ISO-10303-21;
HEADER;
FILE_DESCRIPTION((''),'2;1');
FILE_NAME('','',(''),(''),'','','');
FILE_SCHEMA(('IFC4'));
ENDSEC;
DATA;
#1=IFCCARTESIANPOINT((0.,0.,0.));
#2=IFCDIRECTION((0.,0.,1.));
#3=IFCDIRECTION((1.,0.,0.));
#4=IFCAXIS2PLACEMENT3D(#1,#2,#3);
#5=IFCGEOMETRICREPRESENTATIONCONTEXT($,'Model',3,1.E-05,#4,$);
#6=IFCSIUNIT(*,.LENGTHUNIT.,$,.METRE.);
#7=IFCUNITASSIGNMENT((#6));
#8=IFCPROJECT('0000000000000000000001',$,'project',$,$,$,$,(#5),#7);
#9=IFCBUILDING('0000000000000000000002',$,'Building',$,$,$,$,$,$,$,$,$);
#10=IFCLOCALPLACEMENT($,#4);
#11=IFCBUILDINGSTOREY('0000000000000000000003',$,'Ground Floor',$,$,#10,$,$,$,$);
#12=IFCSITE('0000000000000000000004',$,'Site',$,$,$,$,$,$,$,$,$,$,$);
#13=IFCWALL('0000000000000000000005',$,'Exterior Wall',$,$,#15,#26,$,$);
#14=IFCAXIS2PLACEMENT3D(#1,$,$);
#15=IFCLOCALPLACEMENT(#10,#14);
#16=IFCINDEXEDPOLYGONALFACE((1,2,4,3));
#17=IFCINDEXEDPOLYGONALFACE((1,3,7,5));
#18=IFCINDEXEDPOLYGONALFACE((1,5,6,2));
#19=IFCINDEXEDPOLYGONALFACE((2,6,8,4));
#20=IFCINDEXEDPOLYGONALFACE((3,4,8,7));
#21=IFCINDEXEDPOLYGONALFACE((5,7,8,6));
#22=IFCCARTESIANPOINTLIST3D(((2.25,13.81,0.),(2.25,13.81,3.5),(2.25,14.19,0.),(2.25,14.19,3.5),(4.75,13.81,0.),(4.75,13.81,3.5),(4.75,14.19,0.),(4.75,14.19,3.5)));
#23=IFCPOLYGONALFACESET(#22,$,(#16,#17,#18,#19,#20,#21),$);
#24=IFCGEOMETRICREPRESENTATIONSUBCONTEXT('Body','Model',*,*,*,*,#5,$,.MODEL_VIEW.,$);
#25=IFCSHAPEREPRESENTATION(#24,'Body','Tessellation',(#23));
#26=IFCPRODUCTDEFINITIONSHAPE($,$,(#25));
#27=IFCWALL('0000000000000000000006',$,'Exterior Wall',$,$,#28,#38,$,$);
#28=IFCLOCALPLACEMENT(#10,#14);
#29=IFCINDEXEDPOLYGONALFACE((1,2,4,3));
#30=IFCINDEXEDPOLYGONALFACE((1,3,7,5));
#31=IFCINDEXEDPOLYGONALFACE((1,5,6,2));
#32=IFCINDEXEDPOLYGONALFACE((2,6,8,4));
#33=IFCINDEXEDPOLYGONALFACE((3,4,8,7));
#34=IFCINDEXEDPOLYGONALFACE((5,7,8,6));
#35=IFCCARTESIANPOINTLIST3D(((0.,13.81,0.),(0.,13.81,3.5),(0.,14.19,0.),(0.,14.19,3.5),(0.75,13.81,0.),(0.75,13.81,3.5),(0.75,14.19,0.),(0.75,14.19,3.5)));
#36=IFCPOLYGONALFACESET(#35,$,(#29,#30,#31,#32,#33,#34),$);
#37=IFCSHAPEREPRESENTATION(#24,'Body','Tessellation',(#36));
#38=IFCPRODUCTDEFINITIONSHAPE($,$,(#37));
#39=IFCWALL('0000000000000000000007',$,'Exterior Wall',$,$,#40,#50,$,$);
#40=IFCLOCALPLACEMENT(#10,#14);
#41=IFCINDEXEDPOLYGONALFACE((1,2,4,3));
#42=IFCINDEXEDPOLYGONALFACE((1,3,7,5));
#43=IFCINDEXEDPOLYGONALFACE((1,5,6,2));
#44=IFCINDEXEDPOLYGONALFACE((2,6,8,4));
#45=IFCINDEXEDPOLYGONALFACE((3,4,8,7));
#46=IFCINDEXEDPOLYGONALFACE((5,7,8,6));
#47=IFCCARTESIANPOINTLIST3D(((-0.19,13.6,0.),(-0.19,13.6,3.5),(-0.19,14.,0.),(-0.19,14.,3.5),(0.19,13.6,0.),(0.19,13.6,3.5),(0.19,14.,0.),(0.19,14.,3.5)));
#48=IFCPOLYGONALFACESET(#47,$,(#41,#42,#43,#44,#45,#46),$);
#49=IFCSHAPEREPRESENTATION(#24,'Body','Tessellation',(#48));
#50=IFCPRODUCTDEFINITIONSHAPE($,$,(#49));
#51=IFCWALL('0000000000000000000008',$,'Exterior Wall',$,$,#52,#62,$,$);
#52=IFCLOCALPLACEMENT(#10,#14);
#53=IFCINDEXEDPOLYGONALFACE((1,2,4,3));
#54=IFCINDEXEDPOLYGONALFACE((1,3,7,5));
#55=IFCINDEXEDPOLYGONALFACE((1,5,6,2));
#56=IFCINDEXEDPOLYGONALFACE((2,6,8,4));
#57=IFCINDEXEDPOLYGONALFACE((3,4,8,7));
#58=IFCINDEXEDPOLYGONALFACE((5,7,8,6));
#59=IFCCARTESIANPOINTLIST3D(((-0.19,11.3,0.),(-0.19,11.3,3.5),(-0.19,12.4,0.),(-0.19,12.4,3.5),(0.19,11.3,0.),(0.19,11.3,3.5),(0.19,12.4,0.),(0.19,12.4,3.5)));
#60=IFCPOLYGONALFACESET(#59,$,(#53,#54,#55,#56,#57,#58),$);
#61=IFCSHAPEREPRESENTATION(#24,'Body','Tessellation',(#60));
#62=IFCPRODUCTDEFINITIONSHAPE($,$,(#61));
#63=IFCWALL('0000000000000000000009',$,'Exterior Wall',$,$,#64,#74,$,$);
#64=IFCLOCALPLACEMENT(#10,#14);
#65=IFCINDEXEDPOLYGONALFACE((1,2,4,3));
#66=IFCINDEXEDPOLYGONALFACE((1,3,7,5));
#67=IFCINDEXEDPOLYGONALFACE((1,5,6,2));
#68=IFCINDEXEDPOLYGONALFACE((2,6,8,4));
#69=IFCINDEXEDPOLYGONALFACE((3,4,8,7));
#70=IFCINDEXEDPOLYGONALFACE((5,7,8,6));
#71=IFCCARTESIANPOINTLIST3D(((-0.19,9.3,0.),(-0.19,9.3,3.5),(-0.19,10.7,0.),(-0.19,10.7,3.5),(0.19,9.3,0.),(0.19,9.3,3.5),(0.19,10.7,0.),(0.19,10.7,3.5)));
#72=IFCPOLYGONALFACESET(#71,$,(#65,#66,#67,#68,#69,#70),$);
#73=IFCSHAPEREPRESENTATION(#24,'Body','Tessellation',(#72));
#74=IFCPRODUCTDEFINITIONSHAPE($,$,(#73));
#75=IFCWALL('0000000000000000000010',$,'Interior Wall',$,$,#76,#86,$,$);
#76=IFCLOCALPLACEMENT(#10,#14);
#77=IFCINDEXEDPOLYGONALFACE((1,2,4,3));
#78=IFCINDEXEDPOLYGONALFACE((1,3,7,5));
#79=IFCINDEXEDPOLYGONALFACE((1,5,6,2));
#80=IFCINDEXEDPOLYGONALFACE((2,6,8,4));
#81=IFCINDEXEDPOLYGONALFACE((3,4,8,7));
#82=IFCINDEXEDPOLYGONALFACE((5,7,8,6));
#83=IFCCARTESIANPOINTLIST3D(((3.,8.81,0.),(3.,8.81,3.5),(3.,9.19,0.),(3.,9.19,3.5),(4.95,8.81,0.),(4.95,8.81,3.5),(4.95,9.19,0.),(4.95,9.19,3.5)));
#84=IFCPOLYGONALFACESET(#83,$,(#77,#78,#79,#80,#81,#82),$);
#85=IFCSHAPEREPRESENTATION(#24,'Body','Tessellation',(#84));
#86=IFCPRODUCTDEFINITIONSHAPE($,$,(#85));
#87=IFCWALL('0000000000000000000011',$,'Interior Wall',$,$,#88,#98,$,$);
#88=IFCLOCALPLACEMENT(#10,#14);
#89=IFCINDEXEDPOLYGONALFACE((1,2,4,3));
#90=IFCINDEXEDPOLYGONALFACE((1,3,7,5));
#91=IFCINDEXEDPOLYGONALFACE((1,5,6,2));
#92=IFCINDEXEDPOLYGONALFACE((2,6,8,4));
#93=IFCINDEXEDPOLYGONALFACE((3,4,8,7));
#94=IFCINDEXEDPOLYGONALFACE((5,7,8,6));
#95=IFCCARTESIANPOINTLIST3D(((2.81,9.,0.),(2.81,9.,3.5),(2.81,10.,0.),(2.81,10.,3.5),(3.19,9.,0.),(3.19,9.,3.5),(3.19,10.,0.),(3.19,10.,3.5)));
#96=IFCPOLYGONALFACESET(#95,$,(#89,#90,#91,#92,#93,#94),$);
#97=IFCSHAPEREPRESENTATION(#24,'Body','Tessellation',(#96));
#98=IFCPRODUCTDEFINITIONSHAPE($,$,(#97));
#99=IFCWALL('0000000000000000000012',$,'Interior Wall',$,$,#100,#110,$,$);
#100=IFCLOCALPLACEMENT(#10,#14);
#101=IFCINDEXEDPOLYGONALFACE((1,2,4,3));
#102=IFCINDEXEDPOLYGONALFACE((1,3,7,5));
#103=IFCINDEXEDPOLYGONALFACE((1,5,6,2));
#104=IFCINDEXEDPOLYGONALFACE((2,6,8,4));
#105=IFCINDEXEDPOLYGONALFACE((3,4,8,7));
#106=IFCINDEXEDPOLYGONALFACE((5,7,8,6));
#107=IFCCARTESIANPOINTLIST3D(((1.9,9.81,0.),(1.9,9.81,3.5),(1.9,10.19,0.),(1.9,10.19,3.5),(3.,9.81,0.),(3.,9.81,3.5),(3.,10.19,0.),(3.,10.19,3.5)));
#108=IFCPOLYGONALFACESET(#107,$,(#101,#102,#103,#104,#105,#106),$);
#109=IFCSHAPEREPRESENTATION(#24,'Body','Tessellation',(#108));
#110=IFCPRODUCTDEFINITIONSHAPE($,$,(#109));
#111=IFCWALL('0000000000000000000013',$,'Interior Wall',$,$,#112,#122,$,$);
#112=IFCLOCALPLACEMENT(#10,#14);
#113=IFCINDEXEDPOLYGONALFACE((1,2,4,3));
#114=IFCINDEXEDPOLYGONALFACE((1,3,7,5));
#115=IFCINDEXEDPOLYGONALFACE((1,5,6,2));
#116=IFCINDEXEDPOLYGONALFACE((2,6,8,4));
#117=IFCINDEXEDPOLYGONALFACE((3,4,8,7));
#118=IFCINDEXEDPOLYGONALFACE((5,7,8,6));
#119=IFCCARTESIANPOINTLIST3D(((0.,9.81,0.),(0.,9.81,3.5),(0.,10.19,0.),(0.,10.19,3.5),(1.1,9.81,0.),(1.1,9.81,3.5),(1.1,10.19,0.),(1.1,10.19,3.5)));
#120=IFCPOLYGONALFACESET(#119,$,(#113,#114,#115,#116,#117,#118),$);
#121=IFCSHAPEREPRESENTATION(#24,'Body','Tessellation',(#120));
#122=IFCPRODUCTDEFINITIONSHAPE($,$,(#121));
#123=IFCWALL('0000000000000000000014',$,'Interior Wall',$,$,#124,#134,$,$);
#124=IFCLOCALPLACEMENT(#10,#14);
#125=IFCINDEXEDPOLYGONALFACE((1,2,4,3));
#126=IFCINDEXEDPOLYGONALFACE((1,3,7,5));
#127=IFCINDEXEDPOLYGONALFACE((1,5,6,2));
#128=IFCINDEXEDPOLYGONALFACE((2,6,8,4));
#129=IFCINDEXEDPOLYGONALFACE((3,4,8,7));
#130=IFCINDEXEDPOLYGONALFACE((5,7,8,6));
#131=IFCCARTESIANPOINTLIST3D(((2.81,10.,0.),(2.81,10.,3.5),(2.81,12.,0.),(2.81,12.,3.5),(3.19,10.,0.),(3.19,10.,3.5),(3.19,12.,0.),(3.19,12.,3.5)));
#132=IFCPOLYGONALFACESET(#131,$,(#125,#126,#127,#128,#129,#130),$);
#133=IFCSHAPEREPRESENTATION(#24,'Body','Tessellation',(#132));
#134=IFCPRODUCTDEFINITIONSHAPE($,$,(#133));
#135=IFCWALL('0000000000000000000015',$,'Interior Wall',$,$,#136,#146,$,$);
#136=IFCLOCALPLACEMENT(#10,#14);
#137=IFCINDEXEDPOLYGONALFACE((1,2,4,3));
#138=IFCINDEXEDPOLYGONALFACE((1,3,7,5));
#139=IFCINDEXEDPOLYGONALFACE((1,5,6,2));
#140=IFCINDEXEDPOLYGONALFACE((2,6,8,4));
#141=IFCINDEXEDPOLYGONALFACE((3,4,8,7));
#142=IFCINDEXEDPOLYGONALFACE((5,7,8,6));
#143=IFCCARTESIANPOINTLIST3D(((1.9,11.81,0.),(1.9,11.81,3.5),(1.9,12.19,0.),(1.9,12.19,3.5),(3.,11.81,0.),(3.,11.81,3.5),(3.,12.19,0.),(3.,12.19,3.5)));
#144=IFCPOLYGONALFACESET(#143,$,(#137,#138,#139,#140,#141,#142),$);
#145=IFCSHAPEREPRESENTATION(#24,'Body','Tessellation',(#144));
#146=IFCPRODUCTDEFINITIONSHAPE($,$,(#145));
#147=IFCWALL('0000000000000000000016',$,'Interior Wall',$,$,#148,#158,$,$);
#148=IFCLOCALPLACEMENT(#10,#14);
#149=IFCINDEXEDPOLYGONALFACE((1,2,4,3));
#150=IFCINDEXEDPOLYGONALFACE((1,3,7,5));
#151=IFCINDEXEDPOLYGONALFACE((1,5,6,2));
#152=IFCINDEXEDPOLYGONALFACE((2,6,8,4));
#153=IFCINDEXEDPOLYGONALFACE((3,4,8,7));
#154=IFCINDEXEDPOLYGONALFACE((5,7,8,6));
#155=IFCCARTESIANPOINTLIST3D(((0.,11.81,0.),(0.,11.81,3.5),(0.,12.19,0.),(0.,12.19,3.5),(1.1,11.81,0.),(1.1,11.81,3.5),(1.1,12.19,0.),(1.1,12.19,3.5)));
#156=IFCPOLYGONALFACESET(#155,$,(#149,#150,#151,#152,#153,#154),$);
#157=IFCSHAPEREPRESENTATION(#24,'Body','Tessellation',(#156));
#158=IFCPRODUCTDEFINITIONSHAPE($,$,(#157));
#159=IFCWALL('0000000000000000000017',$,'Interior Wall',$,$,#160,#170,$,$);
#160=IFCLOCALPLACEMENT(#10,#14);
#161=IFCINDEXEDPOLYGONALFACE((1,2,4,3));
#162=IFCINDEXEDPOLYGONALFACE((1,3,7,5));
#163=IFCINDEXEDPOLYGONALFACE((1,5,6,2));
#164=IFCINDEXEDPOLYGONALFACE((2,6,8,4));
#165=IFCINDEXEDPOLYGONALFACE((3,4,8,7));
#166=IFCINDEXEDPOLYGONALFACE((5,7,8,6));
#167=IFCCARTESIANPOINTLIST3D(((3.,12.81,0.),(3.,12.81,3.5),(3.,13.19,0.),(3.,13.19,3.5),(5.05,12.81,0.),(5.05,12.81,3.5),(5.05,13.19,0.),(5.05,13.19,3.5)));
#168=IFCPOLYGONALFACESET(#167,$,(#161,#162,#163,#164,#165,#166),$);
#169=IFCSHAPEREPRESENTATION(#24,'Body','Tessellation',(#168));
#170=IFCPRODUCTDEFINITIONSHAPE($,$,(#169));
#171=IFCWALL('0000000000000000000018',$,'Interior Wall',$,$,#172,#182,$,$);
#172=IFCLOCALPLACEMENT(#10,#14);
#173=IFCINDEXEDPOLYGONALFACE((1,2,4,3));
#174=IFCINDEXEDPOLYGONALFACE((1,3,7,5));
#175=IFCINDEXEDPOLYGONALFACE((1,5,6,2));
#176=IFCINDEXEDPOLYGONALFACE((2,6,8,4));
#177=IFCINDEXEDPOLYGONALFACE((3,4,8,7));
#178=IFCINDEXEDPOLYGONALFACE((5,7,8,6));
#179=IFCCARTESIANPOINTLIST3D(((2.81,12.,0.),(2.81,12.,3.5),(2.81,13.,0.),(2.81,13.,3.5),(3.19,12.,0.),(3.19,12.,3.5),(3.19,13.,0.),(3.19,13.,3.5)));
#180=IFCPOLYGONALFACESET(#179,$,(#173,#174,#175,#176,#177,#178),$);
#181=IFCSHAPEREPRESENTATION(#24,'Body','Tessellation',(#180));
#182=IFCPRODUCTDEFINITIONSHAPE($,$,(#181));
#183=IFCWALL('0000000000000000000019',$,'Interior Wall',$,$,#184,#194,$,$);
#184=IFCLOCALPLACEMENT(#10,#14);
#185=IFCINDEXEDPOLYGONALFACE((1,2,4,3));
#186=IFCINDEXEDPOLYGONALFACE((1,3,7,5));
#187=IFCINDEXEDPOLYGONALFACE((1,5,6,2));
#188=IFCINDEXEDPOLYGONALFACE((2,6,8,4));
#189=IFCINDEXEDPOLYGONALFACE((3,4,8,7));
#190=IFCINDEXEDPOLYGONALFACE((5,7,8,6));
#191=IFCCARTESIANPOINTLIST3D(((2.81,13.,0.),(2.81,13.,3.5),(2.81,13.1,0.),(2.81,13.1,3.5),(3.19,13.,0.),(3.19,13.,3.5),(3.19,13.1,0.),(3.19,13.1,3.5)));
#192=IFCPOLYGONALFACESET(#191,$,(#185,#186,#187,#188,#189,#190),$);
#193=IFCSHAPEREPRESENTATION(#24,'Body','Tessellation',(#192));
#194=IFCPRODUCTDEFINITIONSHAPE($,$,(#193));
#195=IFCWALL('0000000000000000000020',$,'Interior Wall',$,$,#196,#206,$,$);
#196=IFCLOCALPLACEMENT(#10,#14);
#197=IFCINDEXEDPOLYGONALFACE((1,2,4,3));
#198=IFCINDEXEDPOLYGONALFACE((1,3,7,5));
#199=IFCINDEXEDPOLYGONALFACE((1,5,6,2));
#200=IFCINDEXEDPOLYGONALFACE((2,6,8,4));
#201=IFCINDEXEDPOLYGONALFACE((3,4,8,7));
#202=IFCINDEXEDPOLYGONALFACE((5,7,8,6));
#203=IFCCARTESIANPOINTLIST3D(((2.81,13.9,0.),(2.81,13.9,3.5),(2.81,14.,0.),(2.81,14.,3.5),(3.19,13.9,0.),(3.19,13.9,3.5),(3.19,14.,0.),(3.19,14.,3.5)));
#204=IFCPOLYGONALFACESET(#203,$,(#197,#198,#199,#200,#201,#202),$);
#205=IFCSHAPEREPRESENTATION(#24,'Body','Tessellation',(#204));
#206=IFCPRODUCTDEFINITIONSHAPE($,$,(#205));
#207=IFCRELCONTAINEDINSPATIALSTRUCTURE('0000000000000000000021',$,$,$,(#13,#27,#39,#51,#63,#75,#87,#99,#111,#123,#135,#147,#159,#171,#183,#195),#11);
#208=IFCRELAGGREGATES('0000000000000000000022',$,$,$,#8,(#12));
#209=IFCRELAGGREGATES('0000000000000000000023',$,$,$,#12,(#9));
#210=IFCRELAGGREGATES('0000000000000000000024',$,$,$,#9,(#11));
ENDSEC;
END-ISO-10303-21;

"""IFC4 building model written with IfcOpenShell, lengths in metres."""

from ifc_helpers import new_model, si_unit, frame, origin_with_axes, place, context, subcontext, project, spatial, indexed_curve, outline, extrude, element, save


model = new_model("IFC4")

# Units and contexts
model_context = context("Model", 3, precision=1e-05, world=origin_with_axes())
body_context = subcontext(model_context, "Body", "Model", "MODEL_VIEW")
ifc_project = project(units=[si_unit("LENGTHUNIT", "METRE")], contexts=[model_context])

# Site, building, storey
site = spatial("IfcSite", under=ifc_project, Name="Site")
building = spatial("IfcBuilding", under=site, Name="Building")
storey_placement = place(None, origin_with_axes())
storey = spatial("IfcBuildingStorey", under=building, at=storey_placement, Name="Ground Floor")

# Walls
wall_1_placement = place(storey_placement, frame((4.75, 14.0, 0.0), z_axis=(0.0, 0.0, 1.0), x_axis=(-1.0, 0.0, 0.0)))
element("IfcWall", 1, at=wall_1_placement, inside=storey, Name="Exterior Wall", context=body_context, shape_type="SweptSolid", body=[
    extrude(outline(indexed_curve([(0.0, 0.0), (0.0, 0.38), (2.5, 0.38), (2.5, 0.0), (0.0, 0.0)], self_intersect=False)), frame((0.0, -0.19, 0.0), z_axis=(0.0, 0.0, 1.0), x_axis=(1.0, 0.0, 0.0)), (0.0, 0.0, 1.0), 3.5),
])
wall_2_placement = place(storey_placement, frame((0.75, 14.0, 0.0), z_axis=(0.0, 0.0, 1.0), x_axis=(-1.0, 0.0, 0.0)))
element("IfcWall", 2, at=wall_2_placement, inside=storey, Name="Exterior Wall", context=body_context, shape_type="SweptSolid", body=[
    extrude(outline(indexed_curve([(0.0, 0.0), (0.0, 0.38), (0.75, 0.38), (0.75, 0.0), (0.0, 0.0)], self_intersect=False)), frame((0.0, -0.19, 0.0), z_axis=(0.0, 0.0, 1.0), x_axis=(1.0, 0.0, 0.0)), (0.0, 0.0, 1.0), 3.5),
])
wall_3_placement = place(storey_placement, frame((0.0, 14.0, 0.0), z_axis=(0.0, 0.0, 1.0), x_axis=(0.0, -1.0, 0.0)))
element("IfcWall", 3, at=wall_3_placement, inside=storey, Name="Exterior Wall", context=body_context, shape_type="SweptSolid", body=[
    extrude(outline(indexed_curve([(0.0, 0.0), (0.0, 0.38), (0.4, 0.38), (0.4, 0.0), (0.0, 0.0)], self_intersect=False)), frame((0.0, -0.19, 0.0), z_axis=(0.0, 0.0, 1.0), x_axis=(1.0, 0.0, 0.0)), (0.0, 0.0, 1.0), 3.5),
])
wall_4_placement = place(storey_placement, frame((0.0, 12.4, 0.0), z_axis=(0.0, 0.0, 1.0), x_axis=(0.0, -1.0, 0.0)))
element("IfcWall", 4, at=wall_4_placement, inside=storey, Name="Exterior Wall", context=body_context, shape_type="SweptSolid", body=[
    extrude(outline(indexed_curve([(0.0, 0.0), (0.0, 0.38), (1.1, 0.38), (1.1, 0.0), (0.0, 0.0)], self_intersect=False)), frame((0.0, -0.19, 0.0), z_axis=(0.0, 0.0, 1.0), x_axis=(1.0, 0.0, 0.0)), (0.0, 0.0, 1.0), 3.5),
])
wall_5_placement = place(storey_placement, frame((0.0, 10.7, 0.0), z_axis=(0.0, 0.0, 1.0), x_axis=(0.0, -1.0, 0.0)))
element("IfcWall", 5, at=wall_5_placement, inside=storey, Name="Exterior Wall", context=body_context, shape_type="SweptSolid", body=[
    extrude(outline(indexed_curve([(0.0, 0.0), (0.0, 0.38), (1.4, 0.38), (1.4, 0.0), (0.0, 0.0)], self_intersect=False)), frame((0.0, -0.19, 0.0), z_axis=(0.0, 0.0, 1.0), x_axis=(1.0, 0.0, 0.0)), (0.0, 0.0, 1.0), 3.5),
])
wall_6_placement = place(storey_placement, frame((4.95, 9.0, 0.0), z_axis=(0.0, 0.0, 1.0), x_axis=(-1.0, 0.0, 0.0)))
element("IfcWall", 6, at=wall_6_placement, inside=storey, Name="Interior Wall", context=body_context, shape_type="SweptSolid", body=[
    extrude(outline(indexed_curve([(0.0, 0.0), (0.0, 0.38), (1.95, 0.38), (1.95, 0.0), (0.0, 0.0)], self_intersect=False)), frame((0.0, -0.19, 0.0), z_axis=(0.0, 0.0, 1.0), x_axis=(1.0, 0.0, 0.0)), (0.0, 0.0, 1.0), 3.5),
])
wall_7_placement = place(storey_placement, frame((3.0, 9.0, 0.0), z_axis=(0.0, 0.0, 1.0), x_axis=(0.0, 1.0, 0.0)))
element("IfcWall", 7, at=wall_7_placement, inside=storey, Name="Interior Wall", context=body_context, shape_type="SweptSolid", body=[
    extrude(outline(indexed_curve([(0.0, 0.0), (0.0, 0.38), (1.0, 0.38), (1.0, 0.0), (0.0, 0.0)], self_intersect=False)), frame((0.0, -0.19, 0.0), z_axis=(0.0, 0.0, 1.0), x_axis=(1.0, 0.0, 0.0)), (0.0, 0.0, 1.0), 3.5),
])
for number, where, z_axis, x_axis, name in (
    (8, (3.0, 10.0, 0.0), (0.0, 0.0, 1.0), (-1.0, 0.0, 0.0), "Interior Wall"),
    (9, (1.1, 10.0, 0.0), (0.0, 0.0, 1.0), (-1.0, 0.0, 0.0), "Interior Wall"),
):
    element("IfcWall", number, at=place(storey_placement, frame(where, z_axis=z_axis, x_axis=x_axis)), inside=storey, Name=name, context=body_context, shape_type="SweptSolid", body=[
        extrude(outline(indexed_curve([(0.0, 0.0), (0.0, 0.38), (1.1, 0.38), (1.1, 0.0), (0.0, 0.0)], self_intersect=False)), frame((0.0, -0.19, 0.0), z_axis=(0.0, 0.0, 1.0), x_axis=(1.0, 0.0, 0.0)), (0.0, 0.0, 1.0), 3.5),
    ])
wall_8_placement = place(storey_placement, frame((3.0, 10.0, 0.0), z_axis=(0.0, 0.0, 1.0), x_axis=(0.0, 1.0, 0.0)))
element("IfcWall", 10, at=wall_8_placement, inside=storey, Name="Interior Wall", context=body_context, shape_type="SweptSolid", body=[
    extrude(outline(indexed_curve([(0.0, 0.0), (0.0, 0.38), (2.0, 0.38), (2.0, 0.0), (0.0, 0.0)], self_intersect=False)), frame((0.0, -0.19, 0.0), z_axis=(0.0, 0.0, 1.0), x_axis=(1.0, 0.0, 0.0)), (0.0, 0.0, 1.0), 3.5),
])
for number, where, z_axis, x_axis, name in (
    (11, (3.0, 12.0, 0.0), (0.0, 0.0, 1.0), (-1.0, 0.0, 0.0), "Interior Wall"),
    (12, (1.1, 12.0, 0.0), (0.0, 0.0, 1.0), (-1.0, 0.0, 0.0), "Interior Wall"),
):
    element("IfcWall", number, at=place(storey_placement, frame(where, z_axis=z_axis, x_axis=x_axis)), inside=storey, Name=name, context=body_context, shape_type="SweptSolid", body=[
        extrude(outline(indexed_curve([(0.0, 0.0), (0.0, 0.38), (1.1, 0.38), (1.1, 0.0), (0.0, 0.0)], self_intersect=False)), frame((0.0, -0.19, 0.0), z_axis=(0.0, 0.0, 1.0), x_axis=(1.0, 0.0, 0.0)), (0.0, 0.0, 1.0), 3.5),
    ])
wall_9_placement = place(storey_placement, frame((5.05, 13.0, 0.0), z_axis=(0.0, 0.0, 1.0), x_axis=(-1.0, 0.0, 0.0)))
element("IfcWall", 13, at=wall_9_placement, inside=storey, Name="Interior Wall", context=body_context, shape_type="SweptSolid", body=[
    extrude(outline(indexed_curve([(0.0, 0.0), (0.0, 0.38), (2.05, 0.38), (2.05, 0.0), (0.0, 0.0)], self_intersect=False)), frame((0.0, -0.19, 0.0), z_axis=(0.0, 0.0, 1.0), x_axis=(1.0, 0.0, 0.0)), (0.0, 0.0, 1.0), 3.5),
])
wall_10_placement = place(storey_placement, frame((3.0, 13.0, 0.0), z_axis=(0.0, 0.0, 1.0), x_axis=(0.0, -1.0, 0.0)))
element("IfcWall", 14, at=wall_10_placement, inside=storey, Name="Interior Wall", context=body_context, shape_type="SweptSolid", body=[
    extrude(outline(indexed_curve([(0.0, 0.0), (0.0, 0.38), (1.0, 0.38), (1.0, 0.0), (0.0, 0.0)], self_intersect=False)), frame((0.0, -0.19, 0.0), z_axis=(0.0, 0.0, 1.0), x_axis=(1.0, 0.0, 0.0)), (0.0, 0.0, 1.0), 3.5),
])
for number, where, z_axis, x_axis, name in (
    (15, (3.0, 13.0, 0.0), (0.0, 0.0, 1.0), (0.0, 1.0, 0.0), "Interior Wall"),
    (16, (3.0, 13.9, 0.0), (0.0, 0.0, 1.0), (0.0, 1.0, 0.0), "Interior Wall"),
):
    element("IfcWall", number, at=place(storey_placement, frame(where, z_axis=z_axis, x_axis=x_axis)), inside=storey, Name=name, context=body_context, shape_type="SweptSolid", body=[
        extrude(outline(indexed_curve([(0.0, 0.0), (0.0, 0.38), (0.1, 0.38), (0.1, 0.0), (0.0, 0.0)], self_intersect=False)), frame((0.0, -0.19, 0.0), z_axis=(0.0, 0.0, 1.0), x_axis=(1.0, 0.0, 0.0)), (0.0, 0.0, 1.0), 3.5),
    ])

save(model, "model.ifc")
